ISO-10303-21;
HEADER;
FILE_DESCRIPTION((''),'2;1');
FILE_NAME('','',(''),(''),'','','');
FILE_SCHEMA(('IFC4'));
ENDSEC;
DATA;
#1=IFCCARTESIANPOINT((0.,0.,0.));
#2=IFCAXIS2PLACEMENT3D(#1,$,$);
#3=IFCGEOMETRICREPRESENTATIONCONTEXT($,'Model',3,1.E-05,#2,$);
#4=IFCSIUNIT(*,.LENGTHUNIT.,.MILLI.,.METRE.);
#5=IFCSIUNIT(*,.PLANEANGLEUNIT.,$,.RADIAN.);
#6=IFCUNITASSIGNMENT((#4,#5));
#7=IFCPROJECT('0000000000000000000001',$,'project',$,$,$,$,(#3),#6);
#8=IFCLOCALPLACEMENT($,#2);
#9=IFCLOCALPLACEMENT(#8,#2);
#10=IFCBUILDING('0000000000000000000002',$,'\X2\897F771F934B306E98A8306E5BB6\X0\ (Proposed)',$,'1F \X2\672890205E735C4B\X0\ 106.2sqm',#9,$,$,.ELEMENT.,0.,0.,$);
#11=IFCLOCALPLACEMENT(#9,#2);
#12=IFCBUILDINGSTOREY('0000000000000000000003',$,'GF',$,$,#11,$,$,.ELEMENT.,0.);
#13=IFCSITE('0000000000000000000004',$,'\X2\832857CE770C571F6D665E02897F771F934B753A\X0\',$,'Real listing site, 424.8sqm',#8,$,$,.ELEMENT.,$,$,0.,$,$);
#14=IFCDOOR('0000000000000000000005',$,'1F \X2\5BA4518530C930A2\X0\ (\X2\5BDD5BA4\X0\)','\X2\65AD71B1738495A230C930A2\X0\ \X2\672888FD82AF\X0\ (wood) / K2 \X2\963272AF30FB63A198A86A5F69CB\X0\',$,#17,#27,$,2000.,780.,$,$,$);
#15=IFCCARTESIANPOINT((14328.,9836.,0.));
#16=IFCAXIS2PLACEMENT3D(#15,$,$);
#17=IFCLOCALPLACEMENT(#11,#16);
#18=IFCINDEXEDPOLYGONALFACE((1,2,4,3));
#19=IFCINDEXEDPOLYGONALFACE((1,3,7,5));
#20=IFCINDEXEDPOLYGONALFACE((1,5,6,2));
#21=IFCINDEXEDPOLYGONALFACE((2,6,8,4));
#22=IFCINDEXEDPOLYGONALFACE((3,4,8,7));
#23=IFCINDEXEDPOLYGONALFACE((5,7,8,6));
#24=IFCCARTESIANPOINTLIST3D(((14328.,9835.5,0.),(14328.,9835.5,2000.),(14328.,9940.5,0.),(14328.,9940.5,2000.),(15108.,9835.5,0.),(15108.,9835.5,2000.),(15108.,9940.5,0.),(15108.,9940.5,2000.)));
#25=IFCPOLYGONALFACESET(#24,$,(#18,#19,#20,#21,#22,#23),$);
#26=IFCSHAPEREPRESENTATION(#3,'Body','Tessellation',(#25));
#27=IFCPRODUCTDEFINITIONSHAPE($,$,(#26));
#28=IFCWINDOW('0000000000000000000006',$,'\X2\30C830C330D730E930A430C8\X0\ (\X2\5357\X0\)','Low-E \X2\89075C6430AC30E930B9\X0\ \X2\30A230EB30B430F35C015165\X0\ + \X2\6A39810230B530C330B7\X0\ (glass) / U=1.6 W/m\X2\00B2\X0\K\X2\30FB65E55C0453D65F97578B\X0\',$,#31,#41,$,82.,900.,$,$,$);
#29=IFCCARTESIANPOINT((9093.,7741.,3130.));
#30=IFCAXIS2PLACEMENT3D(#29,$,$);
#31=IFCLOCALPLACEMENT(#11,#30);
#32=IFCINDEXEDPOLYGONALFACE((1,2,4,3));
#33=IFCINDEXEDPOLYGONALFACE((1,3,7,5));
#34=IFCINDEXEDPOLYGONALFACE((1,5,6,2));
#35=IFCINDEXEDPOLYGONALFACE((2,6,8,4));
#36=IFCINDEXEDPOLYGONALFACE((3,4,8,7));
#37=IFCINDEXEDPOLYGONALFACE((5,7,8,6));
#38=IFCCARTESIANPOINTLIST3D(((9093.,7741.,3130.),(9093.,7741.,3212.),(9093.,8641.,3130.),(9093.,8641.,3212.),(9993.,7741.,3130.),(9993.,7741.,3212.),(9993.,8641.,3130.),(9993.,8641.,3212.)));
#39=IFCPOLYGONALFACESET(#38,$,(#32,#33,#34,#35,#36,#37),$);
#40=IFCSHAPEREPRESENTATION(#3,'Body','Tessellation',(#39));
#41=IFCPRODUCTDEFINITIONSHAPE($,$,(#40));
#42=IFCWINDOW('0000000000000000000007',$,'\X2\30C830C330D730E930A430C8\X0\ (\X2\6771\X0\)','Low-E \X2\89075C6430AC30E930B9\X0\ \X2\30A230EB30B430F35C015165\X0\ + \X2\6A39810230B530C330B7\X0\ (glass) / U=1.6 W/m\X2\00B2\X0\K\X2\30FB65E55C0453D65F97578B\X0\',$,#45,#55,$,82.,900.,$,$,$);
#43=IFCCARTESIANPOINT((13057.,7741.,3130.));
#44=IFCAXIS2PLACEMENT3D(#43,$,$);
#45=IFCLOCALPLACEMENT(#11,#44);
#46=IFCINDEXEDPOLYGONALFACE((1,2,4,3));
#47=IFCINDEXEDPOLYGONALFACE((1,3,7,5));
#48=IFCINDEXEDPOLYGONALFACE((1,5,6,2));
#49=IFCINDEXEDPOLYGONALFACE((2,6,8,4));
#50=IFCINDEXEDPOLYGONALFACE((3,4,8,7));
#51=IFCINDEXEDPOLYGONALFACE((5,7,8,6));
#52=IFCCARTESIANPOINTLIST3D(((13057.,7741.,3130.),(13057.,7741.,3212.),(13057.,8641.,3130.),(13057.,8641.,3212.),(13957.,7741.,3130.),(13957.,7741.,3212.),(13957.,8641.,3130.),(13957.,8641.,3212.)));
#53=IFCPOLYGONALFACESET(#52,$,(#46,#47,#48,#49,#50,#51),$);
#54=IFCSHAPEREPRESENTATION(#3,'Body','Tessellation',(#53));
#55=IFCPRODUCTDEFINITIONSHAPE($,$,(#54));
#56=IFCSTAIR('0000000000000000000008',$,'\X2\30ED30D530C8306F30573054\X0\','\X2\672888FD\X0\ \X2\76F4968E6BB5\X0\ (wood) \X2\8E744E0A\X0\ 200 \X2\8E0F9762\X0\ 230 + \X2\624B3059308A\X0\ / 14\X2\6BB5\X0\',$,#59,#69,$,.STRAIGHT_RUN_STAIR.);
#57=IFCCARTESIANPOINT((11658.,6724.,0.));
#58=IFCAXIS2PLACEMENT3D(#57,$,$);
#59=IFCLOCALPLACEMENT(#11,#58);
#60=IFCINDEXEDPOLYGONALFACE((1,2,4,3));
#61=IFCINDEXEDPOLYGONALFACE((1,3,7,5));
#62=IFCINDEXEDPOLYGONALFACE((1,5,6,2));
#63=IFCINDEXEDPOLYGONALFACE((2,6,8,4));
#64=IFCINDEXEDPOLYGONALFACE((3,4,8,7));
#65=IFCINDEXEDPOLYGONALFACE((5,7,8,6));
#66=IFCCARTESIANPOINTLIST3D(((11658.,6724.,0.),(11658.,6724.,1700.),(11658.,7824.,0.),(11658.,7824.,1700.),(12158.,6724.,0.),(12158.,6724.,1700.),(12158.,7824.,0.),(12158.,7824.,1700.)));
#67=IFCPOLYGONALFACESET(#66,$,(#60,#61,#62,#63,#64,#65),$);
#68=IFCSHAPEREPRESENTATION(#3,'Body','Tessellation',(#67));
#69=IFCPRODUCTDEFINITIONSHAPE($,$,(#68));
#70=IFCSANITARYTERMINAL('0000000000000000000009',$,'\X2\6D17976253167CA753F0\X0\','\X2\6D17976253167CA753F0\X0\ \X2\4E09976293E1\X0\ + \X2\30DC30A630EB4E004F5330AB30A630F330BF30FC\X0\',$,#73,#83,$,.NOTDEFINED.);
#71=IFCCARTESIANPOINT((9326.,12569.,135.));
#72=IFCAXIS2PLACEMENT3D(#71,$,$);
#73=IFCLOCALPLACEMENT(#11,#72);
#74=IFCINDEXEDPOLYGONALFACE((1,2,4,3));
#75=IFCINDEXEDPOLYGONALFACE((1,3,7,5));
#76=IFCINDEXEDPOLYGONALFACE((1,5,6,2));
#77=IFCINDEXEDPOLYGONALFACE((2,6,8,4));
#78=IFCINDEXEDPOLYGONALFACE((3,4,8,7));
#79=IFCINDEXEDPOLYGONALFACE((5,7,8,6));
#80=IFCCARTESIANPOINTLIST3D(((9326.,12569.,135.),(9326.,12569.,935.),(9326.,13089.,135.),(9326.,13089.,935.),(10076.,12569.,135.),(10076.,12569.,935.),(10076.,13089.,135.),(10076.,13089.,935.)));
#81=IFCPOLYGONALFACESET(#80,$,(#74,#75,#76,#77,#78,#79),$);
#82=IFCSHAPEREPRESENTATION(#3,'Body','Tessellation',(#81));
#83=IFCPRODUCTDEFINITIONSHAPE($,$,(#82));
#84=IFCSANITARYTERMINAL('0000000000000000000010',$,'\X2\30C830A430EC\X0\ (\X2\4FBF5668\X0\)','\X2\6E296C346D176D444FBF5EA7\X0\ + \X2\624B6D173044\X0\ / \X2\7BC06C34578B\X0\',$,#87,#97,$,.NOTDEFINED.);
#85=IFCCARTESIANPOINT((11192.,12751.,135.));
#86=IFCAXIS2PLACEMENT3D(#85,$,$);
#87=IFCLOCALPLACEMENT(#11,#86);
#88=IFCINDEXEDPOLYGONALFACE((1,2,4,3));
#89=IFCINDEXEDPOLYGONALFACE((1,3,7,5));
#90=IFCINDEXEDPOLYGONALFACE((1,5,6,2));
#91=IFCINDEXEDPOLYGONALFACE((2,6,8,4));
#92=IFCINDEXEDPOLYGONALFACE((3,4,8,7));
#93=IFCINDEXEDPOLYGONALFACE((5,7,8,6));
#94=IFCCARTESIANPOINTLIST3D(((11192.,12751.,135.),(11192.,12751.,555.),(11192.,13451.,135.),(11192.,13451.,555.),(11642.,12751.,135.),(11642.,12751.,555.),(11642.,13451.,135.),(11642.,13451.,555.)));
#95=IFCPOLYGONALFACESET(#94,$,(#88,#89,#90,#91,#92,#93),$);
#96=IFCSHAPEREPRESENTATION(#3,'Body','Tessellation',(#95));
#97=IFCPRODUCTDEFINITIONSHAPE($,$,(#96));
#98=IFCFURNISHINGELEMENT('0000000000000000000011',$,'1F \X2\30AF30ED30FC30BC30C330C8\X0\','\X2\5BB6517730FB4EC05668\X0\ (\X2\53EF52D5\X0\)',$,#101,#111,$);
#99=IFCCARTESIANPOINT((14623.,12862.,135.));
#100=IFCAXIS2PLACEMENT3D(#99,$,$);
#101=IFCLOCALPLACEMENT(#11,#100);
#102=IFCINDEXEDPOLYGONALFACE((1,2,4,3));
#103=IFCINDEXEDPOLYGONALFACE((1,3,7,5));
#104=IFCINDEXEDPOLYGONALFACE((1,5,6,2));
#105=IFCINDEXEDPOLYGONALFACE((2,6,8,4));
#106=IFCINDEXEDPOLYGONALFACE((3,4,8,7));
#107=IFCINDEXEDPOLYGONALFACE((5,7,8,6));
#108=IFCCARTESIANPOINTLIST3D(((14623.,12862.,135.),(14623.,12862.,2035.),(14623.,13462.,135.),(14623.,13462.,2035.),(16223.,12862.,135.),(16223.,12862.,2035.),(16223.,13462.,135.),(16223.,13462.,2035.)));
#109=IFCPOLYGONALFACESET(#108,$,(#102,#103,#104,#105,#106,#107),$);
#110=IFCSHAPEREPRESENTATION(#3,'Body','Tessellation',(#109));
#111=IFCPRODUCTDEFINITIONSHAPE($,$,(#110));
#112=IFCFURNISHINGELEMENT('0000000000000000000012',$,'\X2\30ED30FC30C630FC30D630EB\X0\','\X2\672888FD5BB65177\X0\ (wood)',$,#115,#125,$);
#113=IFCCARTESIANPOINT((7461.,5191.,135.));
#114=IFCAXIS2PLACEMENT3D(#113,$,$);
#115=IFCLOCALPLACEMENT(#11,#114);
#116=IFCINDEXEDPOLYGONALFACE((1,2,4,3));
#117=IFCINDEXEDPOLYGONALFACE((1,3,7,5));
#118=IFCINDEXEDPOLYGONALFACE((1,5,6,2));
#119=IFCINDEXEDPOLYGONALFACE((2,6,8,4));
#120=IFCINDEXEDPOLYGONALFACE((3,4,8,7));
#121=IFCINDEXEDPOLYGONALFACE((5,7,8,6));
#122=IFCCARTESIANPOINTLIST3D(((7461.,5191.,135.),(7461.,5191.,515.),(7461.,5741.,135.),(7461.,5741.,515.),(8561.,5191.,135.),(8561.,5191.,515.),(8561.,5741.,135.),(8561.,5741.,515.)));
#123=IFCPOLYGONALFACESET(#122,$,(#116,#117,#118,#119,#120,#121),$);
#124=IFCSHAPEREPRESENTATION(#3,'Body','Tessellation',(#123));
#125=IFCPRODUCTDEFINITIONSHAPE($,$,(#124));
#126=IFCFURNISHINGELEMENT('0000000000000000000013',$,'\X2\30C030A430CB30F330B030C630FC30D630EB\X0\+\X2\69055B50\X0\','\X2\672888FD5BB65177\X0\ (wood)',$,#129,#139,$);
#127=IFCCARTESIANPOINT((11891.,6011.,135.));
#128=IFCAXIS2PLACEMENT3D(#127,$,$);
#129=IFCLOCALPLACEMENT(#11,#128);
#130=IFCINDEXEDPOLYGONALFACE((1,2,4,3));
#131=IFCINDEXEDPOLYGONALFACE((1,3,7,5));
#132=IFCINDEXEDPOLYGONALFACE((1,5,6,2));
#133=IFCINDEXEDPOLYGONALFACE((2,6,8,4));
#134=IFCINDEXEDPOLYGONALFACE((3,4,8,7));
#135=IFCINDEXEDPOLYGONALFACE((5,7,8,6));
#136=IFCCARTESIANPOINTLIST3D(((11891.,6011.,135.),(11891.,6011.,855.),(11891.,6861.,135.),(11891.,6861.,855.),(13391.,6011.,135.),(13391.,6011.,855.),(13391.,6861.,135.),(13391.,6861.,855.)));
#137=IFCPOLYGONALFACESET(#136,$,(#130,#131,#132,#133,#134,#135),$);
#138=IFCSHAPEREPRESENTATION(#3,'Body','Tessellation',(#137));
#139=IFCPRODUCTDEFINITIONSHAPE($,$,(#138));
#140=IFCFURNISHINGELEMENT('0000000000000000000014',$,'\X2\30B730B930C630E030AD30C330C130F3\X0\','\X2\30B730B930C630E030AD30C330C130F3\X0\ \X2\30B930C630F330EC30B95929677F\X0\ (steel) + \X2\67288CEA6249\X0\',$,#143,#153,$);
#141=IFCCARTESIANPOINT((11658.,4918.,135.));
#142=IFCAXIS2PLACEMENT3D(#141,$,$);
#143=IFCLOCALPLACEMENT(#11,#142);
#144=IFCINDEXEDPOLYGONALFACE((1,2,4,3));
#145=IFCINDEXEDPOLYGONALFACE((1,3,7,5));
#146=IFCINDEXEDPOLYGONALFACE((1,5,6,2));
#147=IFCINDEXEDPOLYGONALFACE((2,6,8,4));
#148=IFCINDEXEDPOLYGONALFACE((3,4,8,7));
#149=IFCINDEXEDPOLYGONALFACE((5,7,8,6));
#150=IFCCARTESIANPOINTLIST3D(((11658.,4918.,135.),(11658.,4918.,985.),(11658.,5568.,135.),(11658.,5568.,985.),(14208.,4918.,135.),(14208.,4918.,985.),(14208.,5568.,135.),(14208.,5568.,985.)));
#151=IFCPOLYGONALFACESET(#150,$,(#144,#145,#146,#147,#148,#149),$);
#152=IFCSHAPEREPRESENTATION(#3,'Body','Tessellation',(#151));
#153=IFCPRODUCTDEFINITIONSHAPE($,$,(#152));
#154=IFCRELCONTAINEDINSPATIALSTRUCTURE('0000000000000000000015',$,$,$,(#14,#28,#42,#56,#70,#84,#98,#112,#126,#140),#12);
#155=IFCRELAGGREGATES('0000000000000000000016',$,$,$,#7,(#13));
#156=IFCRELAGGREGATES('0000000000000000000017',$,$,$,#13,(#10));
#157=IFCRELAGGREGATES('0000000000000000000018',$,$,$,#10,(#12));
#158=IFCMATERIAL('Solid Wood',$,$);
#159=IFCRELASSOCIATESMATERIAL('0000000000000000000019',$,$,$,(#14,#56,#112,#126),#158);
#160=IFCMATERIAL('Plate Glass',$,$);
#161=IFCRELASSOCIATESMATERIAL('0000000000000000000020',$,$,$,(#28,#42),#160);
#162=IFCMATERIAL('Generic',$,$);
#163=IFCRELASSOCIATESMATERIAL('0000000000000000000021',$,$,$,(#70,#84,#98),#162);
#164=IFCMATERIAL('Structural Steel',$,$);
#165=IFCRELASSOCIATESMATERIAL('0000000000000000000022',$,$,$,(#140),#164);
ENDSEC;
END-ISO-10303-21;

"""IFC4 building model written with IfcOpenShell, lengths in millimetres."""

from ifc_helpers import new_model, si_unit, frame, frame_2d, origin, place, context, project, spatial, rectangle, extrude, material, element, save


model = new_model("IFC4")

# Units and contexts
model_context = context("Model", 3, precision=1e-05, world=origin())
ifc_project = project(units=[si_unit("LENGTHUNIT", "METRE", prefix="MILLI"), si_unit("PLANEANGLEUNIT", "RADIAN")], contexts=[model_context])

# Site, building, storey
site_placement = place(None, origin())
site = spatial("IfcSite", under=ifc_project, at=site_placement, Name="茨城県土浦市西真鍋町", ObjectType="Real listing site, 424.8sqm", CompositionType="ELEMENT", RefElevation=0.0)
building_placement = place(site_placement, origin())
building = spatial("IfcBuilding", under=site, at=building_placement, Name="西真鍋の風の家 (Proposed)", ObjectType="1F 木造平屋 106.2sqm", CompositionType="ELEMENT", ElevationOfRefHeight=0.0, ElevationOfTerrain=0.0)
storey_placement = place(building_placement, origin())
storey = spatial("IfcBuildingStorey", under=building, at=storey_placement, Name="GF", CompositionType="ELEMENT", Elevation=0.0)

# Shared definitions
ifc_material_1 = material(Name="Solid Wood")
ifc_material_2 = material(Name="Plate Glass")

# Door
door_placement = place(storey_placement, frame((14328.0, 9836.0, 0.0)))
element("IfcDoor", 1, at=door_placement, inside=storey, material=ifc_material_1, Name="1F 室内ドア (寝室)", Description="断熱玄関ドア 木製芯 (wood) / K2 防犯・採風機構", OverallHeight=2000.0, OverallWidth=780.0, context=model_context, shape_type="SweptSolid", body=[
    extrude(rectangle(XDim=780.0, YDim=105.0, at=frame_2d((390.0, 52.0))), frame((14328.0, 9836.0, 0.0)), (0.0, 0.0, 1.0), 2000.0),
])

# Windows
window_1_placement = place(storey_placement, frame((9093.0, 7741.0, 3130.0)))
element("IfcWindow", 2, at=window_1_placement, inside=storey, material=ifc_material_2, Name="トップライト (南)", Description="Low-E 複層ガラス アルゴン封入 + 樹脂サッシ (glass) / U=1.6 W/m²K・日射取得型", OverallHeight=82.0, OverallWidth=900.0, context=model_context, shape_type="SweptSolid", body=[
    extrude(rectangle(XDim=900.0, YDim=900.0, at=frame_2d((450.0, 450.0))), frame((9093.0, 7741.0, 3130.0)), (0.0, 0.0, 1.0), 82.0),
])
window_2_placement = place(storey_placement, frame((13057.0, 7741.0, 3130.0)))
element("IfcWindow", 3, at=window_2_placement, inside=storey, material=ifc_material_2, Name="トップライト (東)", Description="Low-E 複層ガラス アルゴン封入 + 樹脂サッシ (glass) / U=1.6 W/m²K・日射取得型", OverallHeight=82.0, OverallWidth=900.0, context=model_context, shape_type="SweptSolid", body=[
    extrude(rectangle(XDim=900.0, YDim=900.0, at=frame_2d((450.0, 450.0))), frame((13057.0, 7741.0, 3130.0)), (0.0, 0.0, 1.0), 82.0),
])

# Stair
stair_placement = place(storey_placement, frame((11658.0, 6724.0, 0.0)))
element("IfcStair", 4, at=stair_placement, inside=storey, material=ifc_material_1, Name="ロフトはしご", Description="木製 直階段 (wood) 蹴上 200 踏面 230 + 手すり / 14段", PredefinedType="STRAIGHT_RUN_STAIR", context=model_context, shape_type="SweptSolid", body=[
    extrude(rectangle(XDim=500.0, YDim=1100.0, at=frame_2d((250.0, 550.0))), frame((11658.0, 6724.0, 0.0)), (0.0, 0.0, 1.0), 1700.0),
])

# Sanitary terminals
ifc_material_3 = material(Name="Generic")
sanitary_terminal_1_placement = place(storey_placement, frame((9326.0, 12569.0, 135.0)))
element("IfcSanitaryTerminal", 5, at=sanitary_terminal_1_placement, inside=storey, material=ifc_material_3, Name="洗面化粧台", Description="洗面化粧台 三面鏡 + ボウル一体カウンター", PredefinedType="NOTDEFINED", context=model_context, shape_type="SweptSolid", body=[
    extrude(rectangle(XDim=750.0, YDim=520.0, at=frame_2d((375.0, 260.0))), frame((9326.0, 12569.0, 135.0)), (0.0, 0.0, 1.0), 800.0),
])
sanitary_terminal_2_placement = place(storey_placement, frame((11192.0, 12751.0, 135.0)))
element("IfcSanitaryTerminal", 6, at=sanitary_terminal_2_placement, inside=storey, material=ifc_material_3, Name="トイレ (便器)", Description="温水洗浄便座 + 手洗い / 節水型", PredefinedType="NOTDEFINED", context=model_context, shape_type="SweptSolid", body=[
    extrude(rectangle(XDim=450.0, YDim=700.0, at=frame_2d((225.0, 350.0))), frame((11192.0, 12751.0, 135.0)), (0.0, 0.0, 1.0), 420.0),
])

# Furnishing elements
furnishing_1_placement = place(storey_placement, frame((14623.0, 12862.0, 135.0)))
element("IfcFurnishingElement", 7, at=furnishing_1_placement, inside=storey, material=ifc_material_3, Name="1F クローゼット", Description="家具・什器 (可動)", context=model_context, shape_type="SweptSolid", body=[
    extrude(rectangle(XDim=1600.0, YDim=600.0, at=frame_2d((800.0, 300.0))), frame((14623.0, 12862.0, 135.0)), (0.0, 0.0, 1.0), 1900.0),
])
furnishing_2_placement = place(storey_placement, frame((7461.0, 5191.0, 135.0)))
element("IfcFurnishingElement", 8, at=furnishing_2_placement, inside=storey, material=ifc_material_1, Name="ローテーブル", Description="木製家具 (wood)", context=model_context, shape_type="SweptSolid", body=[
    extrude(rectangle(XDim=1100.0, YDim=550.0, at=frame_2d((550.0, 275.0))), frame((7461.0, 5191.0, 135.0)), (0.0, 0.0, 1.0), 380.0),
])
furnishing_3_placement = place(storey_placement, frame((11891.0, 6011.0, 135.0)))
element("IfcFurnishingElement", 9, at=furnishing_3_placement, inside=storey, material=ifc_material_1, Name="ダイニングテーブル+椅子", Description="木製家具 (wood)", context=model_context, shape_type="SweptSolid", body=[
    extrude(rectangle(XDim=1500.0, YDim=850.0, at=frame_2d((750.0, 425.0))), frame((11891.0, 6011.0, 135.0)), (0.0, 0.0, 1.0), 720.0),
])
ifc_material_4 = material(Name="Structural Steel")
furnishing_4_placement = place(storey_placement, frame((11658.0, 4918.0, 135.0)))
element("IfcFurnishingElement", 10, at=furnishing_4_placement, inside=storey, material=ifc_material_4, Name="システムキッチン", Description="システムキッチン ステンレス天板 (steel) + 木質扉", context=model_context, shape_type="SweptSolid", body=[
    extrude(rectangle(XDim=2550.0, YDim=650.0, at=frame_2d((1275.0, 325.0))), frame((11658.0, 4918.0, 135.0)), (0.0, 0.0, 1.0), 850.0),
])

save(model, "model.ifc")
